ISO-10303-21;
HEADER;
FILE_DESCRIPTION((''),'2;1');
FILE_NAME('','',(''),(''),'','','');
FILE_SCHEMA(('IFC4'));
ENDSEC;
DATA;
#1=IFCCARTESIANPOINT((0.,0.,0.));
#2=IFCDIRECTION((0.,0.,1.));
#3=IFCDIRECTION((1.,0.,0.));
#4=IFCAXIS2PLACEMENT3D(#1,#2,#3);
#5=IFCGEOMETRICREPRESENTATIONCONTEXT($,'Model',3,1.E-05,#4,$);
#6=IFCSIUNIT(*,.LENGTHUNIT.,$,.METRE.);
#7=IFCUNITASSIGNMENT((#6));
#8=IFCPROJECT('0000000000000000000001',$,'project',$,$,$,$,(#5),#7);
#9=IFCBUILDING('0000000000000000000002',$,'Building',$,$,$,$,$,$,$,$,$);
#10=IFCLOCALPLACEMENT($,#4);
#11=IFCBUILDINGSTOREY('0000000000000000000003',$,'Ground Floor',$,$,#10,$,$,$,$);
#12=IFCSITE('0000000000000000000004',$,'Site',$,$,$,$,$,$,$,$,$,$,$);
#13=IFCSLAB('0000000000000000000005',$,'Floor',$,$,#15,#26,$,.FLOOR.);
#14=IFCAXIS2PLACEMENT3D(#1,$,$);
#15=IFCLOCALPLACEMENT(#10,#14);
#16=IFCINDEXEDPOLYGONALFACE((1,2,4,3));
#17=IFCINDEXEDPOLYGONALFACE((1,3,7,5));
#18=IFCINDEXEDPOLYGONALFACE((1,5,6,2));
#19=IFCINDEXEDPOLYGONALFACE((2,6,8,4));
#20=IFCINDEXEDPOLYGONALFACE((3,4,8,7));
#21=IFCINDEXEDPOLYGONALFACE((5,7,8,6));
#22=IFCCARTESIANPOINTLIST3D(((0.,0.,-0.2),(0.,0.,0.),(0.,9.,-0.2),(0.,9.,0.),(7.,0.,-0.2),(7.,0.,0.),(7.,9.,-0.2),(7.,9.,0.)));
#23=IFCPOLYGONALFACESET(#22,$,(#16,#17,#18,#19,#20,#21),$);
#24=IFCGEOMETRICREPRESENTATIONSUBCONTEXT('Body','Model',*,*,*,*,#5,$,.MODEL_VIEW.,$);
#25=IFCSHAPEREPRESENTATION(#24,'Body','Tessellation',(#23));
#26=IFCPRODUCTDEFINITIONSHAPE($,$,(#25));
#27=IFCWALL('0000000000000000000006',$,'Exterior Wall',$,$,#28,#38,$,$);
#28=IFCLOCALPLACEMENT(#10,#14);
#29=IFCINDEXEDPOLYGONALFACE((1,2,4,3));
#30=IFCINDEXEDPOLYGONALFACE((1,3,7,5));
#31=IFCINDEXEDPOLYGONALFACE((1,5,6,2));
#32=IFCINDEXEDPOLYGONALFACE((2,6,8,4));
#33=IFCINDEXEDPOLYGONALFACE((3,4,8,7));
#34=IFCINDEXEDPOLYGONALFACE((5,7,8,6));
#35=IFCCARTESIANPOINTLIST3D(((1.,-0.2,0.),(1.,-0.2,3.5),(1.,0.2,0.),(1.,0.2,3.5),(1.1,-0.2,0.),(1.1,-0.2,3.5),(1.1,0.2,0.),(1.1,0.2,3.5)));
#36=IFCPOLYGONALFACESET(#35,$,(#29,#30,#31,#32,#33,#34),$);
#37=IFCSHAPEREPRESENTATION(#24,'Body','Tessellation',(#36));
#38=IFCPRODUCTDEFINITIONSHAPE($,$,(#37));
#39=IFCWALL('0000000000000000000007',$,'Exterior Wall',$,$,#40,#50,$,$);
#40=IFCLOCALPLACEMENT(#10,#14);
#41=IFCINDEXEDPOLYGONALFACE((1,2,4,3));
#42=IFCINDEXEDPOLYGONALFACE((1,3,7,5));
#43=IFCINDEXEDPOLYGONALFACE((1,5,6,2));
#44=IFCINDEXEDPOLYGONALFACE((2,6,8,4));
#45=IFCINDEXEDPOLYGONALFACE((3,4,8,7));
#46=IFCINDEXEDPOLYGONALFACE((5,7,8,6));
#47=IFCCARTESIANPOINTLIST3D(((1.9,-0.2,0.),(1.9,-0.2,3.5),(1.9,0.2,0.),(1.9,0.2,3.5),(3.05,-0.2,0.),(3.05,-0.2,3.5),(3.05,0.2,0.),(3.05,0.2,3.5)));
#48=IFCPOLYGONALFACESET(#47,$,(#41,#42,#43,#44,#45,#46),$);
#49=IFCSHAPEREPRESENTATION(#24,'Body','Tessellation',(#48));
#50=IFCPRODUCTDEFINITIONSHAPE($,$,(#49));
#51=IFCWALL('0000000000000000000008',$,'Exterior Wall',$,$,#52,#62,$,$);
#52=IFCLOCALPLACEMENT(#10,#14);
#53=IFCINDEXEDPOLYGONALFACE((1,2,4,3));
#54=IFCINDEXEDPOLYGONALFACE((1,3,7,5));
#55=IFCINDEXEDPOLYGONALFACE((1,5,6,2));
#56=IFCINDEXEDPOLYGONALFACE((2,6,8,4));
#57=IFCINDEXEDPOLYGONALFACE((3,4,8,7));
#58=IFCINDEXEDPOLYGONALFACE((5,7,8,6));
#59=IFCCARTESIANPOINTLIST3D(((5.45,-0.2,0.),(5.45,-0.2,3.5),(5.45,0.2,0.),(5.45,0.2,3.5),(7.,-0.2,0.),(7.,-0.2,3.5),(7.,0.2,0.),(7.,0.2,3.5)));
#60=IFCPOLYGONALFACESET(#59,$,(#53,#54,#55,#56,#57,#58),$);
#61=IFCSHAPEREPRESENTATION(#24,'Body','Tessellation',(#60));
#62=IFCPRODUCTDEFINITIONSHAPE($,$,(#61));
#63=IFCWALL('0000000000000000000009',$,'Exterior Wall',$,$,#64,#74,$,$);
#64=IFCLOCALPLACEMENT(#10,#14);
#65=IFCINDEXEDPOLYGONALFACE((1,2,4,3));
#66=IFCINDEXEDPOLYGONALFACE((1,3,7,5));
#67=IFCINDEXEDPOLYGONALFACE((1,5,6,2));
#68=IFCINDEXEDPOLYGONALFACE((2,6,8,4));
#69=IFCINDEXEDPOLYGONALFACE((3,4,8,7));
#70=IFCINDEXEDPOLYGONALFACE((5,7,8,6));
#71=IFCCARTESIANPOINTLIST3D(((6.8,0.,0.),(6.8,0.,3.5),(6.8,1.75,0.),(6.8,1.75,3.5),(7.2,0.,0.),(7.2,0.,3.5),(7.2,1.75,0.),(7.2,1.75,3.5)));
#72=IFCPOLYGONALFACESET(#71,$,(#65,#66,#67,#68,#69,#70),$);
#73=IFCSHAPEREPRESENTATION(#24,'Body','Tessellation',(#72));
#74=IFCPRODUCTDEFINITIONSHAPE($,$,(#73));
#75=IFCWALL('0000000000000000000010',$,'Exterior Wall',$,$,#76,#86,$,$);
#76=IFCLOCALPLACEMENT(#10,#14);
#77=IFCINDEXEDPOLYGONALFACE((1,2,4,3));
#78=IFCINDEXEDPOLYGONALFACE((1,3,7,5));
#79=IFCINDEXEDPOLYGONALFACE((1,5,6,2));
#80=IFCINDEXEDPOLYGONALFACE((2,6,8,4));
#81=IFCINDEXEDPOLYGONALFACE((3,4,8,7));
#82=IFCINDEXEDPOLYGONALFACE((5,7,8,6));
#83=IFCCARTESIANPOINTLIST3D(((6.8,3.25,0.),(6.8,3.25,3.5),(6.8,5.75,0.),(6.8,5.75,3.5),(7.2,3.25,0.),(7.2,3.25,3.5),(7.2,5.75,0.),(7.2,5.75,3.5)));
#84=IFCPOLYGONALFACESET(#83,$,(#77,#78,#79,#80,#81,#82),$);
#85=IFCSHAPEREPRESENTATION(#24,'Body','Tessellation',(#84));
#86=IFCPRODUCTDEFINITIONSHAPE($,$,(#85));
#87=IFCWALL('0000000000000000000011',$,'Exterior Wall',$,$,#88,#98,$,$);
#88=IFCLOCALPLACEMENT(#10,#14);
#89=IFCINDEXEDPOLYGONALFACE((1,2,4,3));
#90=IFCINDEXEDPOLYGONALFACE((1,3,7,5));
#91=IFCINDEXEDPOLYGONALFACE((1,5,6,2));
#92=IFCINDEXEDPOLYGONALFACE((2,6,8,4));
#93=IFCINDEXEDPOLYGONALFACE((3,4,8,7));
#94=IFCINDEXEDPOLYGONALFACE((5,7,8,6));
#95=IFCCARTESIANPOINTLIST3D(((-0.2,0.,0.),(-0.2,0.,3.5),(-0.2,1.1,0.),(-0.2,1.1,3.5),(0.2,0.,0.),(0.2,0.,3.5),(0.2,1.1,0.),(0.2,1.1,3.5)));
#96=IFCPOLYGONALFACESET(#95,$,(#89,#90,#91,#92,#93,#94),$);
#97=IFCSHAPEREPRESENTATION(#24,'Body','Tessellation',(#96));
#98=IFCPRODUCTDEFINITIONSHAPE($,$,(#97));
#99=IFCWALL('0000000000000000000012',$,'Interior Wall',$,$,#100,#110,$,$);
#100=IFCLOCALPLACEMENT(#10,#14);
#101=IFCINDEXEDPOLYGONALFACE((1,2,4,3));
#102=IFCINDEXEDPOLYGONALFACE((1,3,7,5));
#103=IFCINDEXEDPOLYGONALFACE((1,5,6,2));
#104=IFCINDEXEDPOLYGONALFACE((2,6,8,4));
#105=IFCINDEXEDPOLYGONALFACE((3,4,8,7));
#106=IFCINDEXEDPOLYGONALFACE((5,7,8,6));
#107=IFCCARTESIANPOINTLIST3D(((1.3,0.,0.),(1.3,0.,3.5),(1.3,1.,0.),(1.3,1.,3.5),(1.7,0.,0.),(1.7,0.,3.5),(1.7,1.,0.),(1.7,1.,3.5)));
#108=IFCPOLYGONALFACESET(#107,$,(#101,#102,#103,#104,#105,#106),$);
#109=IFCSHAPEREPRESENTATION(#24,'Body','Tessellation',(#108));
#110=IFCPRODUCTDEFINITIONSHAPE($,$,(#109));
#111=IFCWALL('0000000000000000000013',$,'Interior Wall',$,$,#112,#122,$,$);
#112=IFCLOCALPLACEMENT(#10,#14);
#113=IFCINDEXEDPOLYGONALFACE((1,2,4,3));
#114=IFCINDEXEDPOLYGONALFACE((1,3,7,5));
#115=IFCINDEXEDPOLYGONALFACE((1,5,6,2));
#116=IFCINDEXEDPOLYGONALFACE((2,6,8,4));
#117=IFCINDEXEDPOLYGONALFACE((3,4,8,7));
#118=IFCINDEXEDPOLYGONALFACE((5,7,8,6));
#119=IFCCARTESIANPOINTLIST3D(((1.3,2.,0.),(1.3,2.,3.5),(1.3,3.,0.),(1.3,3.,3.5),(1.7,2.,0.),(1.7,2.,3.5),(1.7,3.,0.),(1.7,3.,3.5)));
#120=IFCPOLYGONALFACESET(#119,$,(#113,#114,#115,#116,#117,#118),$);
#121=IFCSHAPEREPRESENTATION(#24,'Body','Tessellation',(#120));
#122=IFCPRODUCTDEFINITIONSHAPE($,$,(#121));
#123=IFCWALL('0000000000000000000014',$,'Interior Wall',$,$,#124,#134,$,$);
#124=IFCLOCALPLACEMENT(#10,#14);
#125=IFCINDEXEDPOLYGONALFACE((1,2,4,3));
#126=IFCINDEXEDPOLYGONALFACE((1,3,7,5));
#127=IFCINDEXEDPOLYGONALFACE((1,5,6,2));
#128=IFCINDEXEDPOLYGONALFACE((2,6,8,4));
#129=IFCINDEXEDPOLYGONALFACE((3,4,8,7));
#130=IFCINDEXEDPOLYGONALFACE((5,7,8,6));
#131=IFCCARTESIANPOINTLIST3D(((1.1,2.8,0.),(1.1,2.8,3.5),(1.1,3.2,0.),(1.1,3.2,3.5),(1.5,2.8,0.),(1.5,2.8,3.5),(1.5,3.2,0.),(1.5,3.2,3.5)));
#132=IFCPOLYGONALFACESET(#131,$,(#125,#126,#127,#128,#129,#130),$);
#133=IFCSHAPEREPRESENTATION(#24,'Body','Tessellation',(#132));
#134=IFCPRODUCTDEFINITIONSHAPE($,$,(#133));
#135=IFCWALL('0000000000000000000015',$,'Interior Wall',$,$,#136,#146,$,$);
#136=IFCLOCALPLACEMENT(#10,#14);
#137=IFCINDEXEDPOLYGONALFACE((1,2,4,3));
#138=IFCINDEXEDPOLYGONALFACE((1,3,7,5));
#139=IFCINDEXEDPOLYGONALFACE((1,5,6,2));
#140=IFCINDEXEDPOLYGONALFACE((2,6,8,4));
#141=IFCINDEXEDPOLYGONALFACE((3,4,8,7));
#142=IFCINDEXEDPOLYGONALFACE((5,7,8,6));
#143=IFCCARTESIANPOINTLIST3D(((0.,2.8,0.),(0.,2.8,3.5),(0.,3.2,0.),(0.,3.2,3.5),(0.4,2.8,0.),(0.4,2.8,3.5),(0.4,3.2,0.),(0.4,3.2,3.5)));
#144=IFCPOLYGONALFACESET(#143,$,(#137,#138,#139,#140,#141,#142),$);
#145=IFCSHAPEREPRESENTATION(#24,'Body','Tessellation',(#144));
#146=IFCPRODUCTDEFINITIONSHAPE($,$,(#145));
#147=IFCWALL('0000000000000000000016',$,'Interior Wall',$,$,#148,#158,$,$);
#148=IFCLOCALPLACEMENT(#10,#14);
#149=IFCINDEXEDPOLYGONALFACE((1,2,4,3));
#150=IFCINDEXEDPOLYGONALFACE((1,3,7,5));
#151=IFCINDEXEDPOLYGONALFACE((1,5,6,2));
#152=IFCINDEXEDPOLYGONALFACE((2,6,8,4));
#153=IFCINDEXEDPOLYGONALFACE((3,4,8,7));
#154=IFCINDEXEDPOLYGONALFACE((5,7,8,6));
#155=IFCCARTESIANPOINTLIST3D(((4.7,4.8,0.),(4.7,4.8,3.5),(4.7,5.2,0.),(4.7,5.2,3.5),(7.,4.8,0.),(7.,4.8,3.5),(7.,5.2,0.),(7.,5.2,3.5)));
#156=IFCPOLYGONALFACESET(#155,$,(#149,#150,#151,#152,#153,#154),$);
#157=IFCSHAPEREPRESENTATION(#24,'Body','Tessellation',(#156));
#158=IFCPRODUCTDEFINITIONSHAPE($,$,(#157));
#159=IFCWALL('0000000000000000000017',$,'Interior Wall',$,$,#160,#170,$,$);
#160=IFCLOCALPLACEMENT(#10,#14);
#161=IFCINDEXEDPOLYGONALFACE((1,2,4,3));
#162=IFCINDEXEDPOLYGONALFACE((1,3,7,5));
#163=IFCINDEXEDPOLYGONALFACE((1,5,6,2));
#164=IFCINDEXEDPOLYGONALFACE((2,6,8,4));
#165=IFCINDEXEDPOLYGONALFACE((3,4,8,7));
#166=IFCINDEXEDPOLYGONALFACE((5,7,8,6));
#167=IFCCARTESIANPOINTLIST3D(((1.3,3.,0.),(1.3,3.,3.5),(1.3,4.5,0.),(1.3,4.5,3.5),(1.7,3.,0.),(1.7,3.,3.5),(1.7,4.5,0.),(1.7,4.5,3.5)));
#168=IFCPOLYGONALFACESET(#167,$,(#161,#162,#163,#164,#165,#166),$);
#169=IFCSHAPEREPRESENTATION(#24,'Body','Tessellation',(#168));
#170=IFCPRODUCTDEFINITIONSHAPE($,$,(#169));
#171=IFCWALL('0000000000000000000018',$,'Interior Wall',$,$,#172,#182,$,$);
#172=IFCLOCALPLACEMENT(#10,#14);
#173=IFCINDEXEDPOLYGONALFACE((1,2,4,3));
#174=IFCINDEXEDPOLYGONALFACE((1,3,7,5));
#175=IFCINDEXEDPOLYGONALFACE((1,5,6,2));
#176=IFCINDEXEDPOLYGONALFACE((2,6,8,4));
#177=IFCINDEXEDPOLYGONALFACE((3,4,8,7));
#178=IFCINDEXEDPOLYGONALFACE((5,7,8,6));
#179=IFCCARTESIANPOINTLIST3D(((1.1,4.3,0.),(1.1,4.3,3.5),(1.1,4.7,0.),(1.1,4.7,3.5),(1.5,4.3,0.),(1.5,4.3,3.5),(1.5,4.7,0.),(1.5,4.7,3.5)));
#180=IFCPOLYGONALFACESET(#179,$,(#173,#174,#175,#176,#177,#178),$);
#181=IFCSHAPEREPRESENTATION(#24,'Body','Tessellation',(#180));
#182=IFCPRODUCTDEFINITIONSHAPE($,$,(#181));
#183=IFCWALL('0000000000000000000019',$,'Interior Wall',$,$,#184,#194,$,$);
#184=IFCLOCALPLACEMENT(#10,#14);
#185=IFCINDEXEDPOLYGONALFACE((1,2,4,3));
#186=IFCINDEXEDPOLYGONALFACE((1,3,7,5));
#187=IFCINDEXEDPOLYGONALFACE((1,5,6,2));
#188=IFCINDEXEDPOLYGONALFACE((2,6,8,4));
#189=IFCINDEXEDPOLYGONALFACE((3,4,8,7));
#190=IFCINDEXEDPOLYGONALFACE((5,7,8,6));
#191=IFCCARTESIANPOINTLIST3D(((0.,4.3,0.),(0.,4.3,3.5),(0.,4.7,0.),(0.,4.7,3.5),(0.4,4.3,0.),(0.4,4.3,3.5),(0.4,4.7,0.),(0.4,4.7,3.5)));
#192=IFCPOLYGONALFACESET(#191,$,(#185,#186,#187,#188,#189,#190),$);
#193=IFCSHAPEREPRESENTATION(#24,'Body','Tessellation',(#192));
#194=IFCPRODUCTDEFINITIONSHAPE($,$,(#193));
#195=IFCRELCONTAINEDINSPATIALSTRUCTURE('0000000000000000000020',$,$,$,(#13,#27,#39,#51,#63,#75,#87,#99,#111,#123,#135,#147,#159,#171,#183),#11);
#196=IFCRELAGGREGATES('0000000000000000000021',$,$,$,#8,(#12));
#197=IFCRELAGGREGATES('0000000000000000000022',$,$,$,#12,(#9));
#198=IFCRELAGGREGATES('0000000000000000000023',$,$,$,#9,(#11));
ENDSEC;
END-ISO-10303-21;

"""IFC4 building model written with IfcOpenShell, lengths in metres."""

from ifc_helpers import new_model, si_unit, frame, origin_with_axes, place, context, subcontext, project, spatial, indexed_curve, outline, extrude, element, save


model = new_model("IFC4")

# Units and contexts
model_context = context("Model", 3, precision=1e-05, world=origin_with_axes())
body_context = subcontext(model_context, "Body", "Model", "MODEL_VIEW")
ifc_project = project(units=[si_unit("LENGTHUNIT", "METRE")], contexts=[model_context])

# Site, building, storey
site = spatial("IfcSite", under=ifc_project, Name="Site")
building = spatial("IfcBuilding", under=site, Name="Building")
storey_placement = place(None, origin_with_axes())
storey = spatial("IfcBuildingStorey", under=building, at=storey_placement, Name="Ground Floor")

# Slab
slab_placement = place(storey_placement, frame((0.0, 0.0, -0.2), z_axis=(0.0, 0.0, 1.0), x_axis=(1.0, 0.0, 0.0)))
element("IfcSlab", 1, at=slab_placement, inside=storey, Name="Floor", PredefinedType="FLOOR", context=body_context, shape_type="SweptSolid", body=[
    extrude(outline(indexed_curve([(0.0, 0.0), (7.0, 0.0), (7.0, 9.0), (0.0, 9.0)])), None, (0.0, 0.0, 1.0), 0.2),
])

# Walls
wall_1_placement = place(storey_placement, frame((1.0, 0.0, 0.0), z_axis=(0.0, 0.0, 1.0), x_axis=(1.0, 0.0, 0.0)))
element("IfcWall", 2, at=wall_1_placement, inside=storey, Name="Exterior Wall", context=body_context, shape_type="SweptSolid", body=[
    extrude(outline(indexed_curve([(0.0, 0.0), (0.0, 0.4), (0.1, 0.4), (0.1, 0.0), (0.0, 0.0)], self_intersect=False)), frame((0.0, -0.2, 0.0), z_axis=(0.0, 0.0, 1.0), x_axis=(1.0, 0.0, 0.0)), (0.0, 0.0, 1.0), 3.5),
])
wall_2_placement = place(storey_placement, frame((1.9, 0.0, 0.0), z_axis=(0.0, 0.0, 1.0), x_axis=(1.0, 0.0, 0.0)))
element("IfcWall", 3, at=wall_2_placement, inside=storey, Name="Exterior Wall", context=body_context, shape_type="SweptSolid", body=[
    extrude(outline(indexed_curve([(0.0, 0.0), (0.0, 0.4), (1.15, 0.4), (1.15, 0.0), (0.0, 0.0)], self_intersect=False)), frame((0.0, -0.2, 0.0), z_axis=(0.0, 0.0, 1.0), x_axis=(1.0, 0.0, 0.0)), (0.0, 0.0, 1.0), 3.5),
])
wall_3_placement = place(storey_placement, frame((5.45, 0.0, 0.0), z_axis=(0.0, 0.0, 1.0), x_axis=(1.0, 0.0, 0.0)))
element("IfcWall", 4, at=wall_3_placement, inside=storey, Name="Exterior Wall", context=body_context, shape_type="SweptSolid", body=[
    extrude(outline(indexed_curve([(0.0, 0.0), (0.0, 0.4), (1.55, 0.4), (1.55, 0.0), (0.0, 0.0)], self_intersect=False)), frame((0.0, -0.2, 0.0), z_axis=(0.0, 0.0, 1.0), x_axis=(1.0, 0.0, 0.0)), (0.0, 0.0, 1.0), 3.5),
])
wall_4_placement = place(storey_placement, frame((7.0, 0.0, 0.0), z_axis=(0.0, 0.0, 1.0), x_axis=(0.0, 1.0, 0.0)))
element("IfcWall", 5, at=wall_4_placement, inside=storey, Name="Exterior Wall", context=body_context, shape_type="SweptSolid", body=[
    extrude(outline(indexed_curve([(0.0, 0.0), (0.0, 0.4), (1.75, 0.4), (1.75, 0.0), (0.0, 0.0)], self_intersect=False)), frame((0.0, -0.2, 0.0), z_axis=(0.0, 0.0, 1.0), x_axis=(1.0, 0.0, 0.0)), (0.0, 0.0, 1.0), 3.5),
])
wall_5_placement = place(storey_placement, frame((7.0, 3.25, 0.0), z_axis=(0.0, 0.0, 1.0), x_axis=(0.0, 1.0, 0.0)))
element("IfcWall", 6, at=wall_5_placement, inside=storey, Name="Exterior Wall", context=body_context, shape_type="SweptSolid", body=[
    extrude(outline(indexed_curve([(0.0, 0.0), (0.0, 0.4), (2.5, 0.4), (2.5, 0.0), (0.0, 0.0)], self_intersect=False)), frame((0.0, -0.2, 0.0), z_axis=(0.0, 0.0, 1.0), x_axis=(1.0, 0.0, 0.0)), (0.0, 0.0, 1.0), 3.5),
])
wall_6_placement = place(storey_placement, frame((0.0, 1.1, 0.0), z_axis=(0.0, 0.0, 1.0), x_axis=(0.0, -1.0, 0.0)))
element("IfcWall", 7, at=wall_6_placement, inside=storey, Name="Exterior Wall", context=body_context, shape_type="SweptSolid", body=[
    extrude(outline(indexed_curve([(0.0, 0.0), (0.0, 0.4), (1.1, 0.4), (1.1, 0.0), (0.0, 0.0)], self_intersect=False)), frame((0.0, -0.2, 0.0), z_axis=(0.0, 0.0, 1.0), x_axis=(1.0, 0.0, 0.0)), (0.0, 0.0, 1.0), 3.5),
])
for number, where, z_axis, x_axis, name in (
    (8, (1.5, 0.0, 0.0), (0.0, 0.0, 1.0), (0.0, 1.0, 0.0), "Interior Wall"),
    (9, (1.5, 2.0, 0.0), (0.0, 0.0, 1.0), (0.0, 1.0, 0.0), "Interior Wall"),
):
    element("IfcWall", number, at=place(storey_placement, frame(where, z_axis=z_axis, x_axis=x_axis)), inside=storey, Name=name, context=body_context, shape_type="SweptSolid", body=[
        extrude(outline(indexed_curve([(0.0, 0.0), (0.0, 0.4), (1.0, 0.4), (1.0, 0.0), (0.0, 0.0)], self_intersect=False)), frame((0.0, -0.2, 0.0), z_axis=(0.0, 0.0, 1.0), x_axis=(1.0, 0.0, 0.0)), (0.0, 0.0, 1.0), 3.5),
    ])
for number, where, z_axis, x_axis, name in (
    (10, (1.5, 3.0, 0.0), (0.0, 0.0, 1.0), (-1.0, 0.0, 0.0), "Interior Wall"),
    (11, (0.4, 3.0, 0.0), (0.0, 0.0, 1.0), (-1.0, 0.0, 0.0), "Interior Wall"),
):
    element("IfcWall", number, at=place(storey_placement, frame(where, z_axis=z_axis, x_axis=x_axis)), inside=storey, Name=name, context=body_context, shape_type="SweptSolid", body=[
        extrude(outline(indexed_curve([(0.0, 0.0), (0.0, 0.4), (0.4, 0.4), (0.4, 0.0), (0.0, 0.0)], self_intersect=False)), frame((0.0, -0.2, 0.0), z_axis=(0.0, 0.0, 1.0), x_axis=(1.0, 0.0, 0.0)), (0.0, 0.0, 1.0), 3.5),
    ])
wall_7_placement = place(storey_placement, frame((7.0, 5.0, 0.0), z_axis=(0.0, 0.0, 1.0), x_axis=(-1.0, 0.0, 0.0)))
element("IfcWall", 12, at=wall_7_placement, inside=storey, Name="Interior Wall", context=body_context, shape_type="SweptSolid", body=[
    extrude(outline(indexed_curve([(0.0, 0.0), (0.0, 0.4), (2.3, 0.4), (2.3, 0.0), (0.0, 0.0)], self_intersect=False)), frame((0.0, -0.2, 0.0), z_axis=(0.0, 0.0, 1.0), x_axis=(1.0, 0.0, 0.0)), (0.0, 0.0, 1.0), 3.5),
])
wall_8_placement = place(storey_placement, frame((1.5, 4.5, 0.0), z_axis=(0.0, 0.0, 1.0), x_axis=(0.0, -1.0, 0.0)))
element("IfcWall", 13, at=wall_8_placement, inside=storey, Name="Interior Wall", context=body_context, shape_type="SweptSolid", body=[
    extrude(outline(indexed_curve([(0.0, 0.0), (0.0, 0.4), (1.5, 0.4), (1.5, 0.0), (0.0, 0.0)], self_intersect=False)), frame((0.0, -0.2, 0.0), z_axis=(0.0, 0.0, 1.0), x_axis=(1.0, 0.0, 0.0)), (0.0, 0.0, 1.0), 3.5),
])
for number, where, z_axis, x_axis, name in (
    (14, (1.5, 4.5, 0.0), (0.0, 0.0, 1.0), (-1.0, 0.0, 0.0), "Interior Wall"),
    (15, (0.4, 4.5, 0.0), (0.0, 0.0, 1.0), (-1.0, 0.0, 0.0), "Interior Wall"),
):
    element("IfcWall", number, at=place(storey_placement, frame(where, z_axis=z_axis, x_axis=x_axis)), inside=storey, Name=name, context=body_context, shape_type="SweptSolid", body=[
        extrude(outline(indexed_curve([(0.0, 0.0), (0.0, 0.4), (0.4, 0.4), (0.4, 0.0), (0.0, 0.0)], self_intersect=False)), frame((0.0, -0.2, 0.0), z_axis=(0.0, 0.0, 1.0), x_axis=(1.0, 0.0, 0.0)), (0.0, 0.0, 1.0), 3.5),
    ])

save(model, "model.ifc")
